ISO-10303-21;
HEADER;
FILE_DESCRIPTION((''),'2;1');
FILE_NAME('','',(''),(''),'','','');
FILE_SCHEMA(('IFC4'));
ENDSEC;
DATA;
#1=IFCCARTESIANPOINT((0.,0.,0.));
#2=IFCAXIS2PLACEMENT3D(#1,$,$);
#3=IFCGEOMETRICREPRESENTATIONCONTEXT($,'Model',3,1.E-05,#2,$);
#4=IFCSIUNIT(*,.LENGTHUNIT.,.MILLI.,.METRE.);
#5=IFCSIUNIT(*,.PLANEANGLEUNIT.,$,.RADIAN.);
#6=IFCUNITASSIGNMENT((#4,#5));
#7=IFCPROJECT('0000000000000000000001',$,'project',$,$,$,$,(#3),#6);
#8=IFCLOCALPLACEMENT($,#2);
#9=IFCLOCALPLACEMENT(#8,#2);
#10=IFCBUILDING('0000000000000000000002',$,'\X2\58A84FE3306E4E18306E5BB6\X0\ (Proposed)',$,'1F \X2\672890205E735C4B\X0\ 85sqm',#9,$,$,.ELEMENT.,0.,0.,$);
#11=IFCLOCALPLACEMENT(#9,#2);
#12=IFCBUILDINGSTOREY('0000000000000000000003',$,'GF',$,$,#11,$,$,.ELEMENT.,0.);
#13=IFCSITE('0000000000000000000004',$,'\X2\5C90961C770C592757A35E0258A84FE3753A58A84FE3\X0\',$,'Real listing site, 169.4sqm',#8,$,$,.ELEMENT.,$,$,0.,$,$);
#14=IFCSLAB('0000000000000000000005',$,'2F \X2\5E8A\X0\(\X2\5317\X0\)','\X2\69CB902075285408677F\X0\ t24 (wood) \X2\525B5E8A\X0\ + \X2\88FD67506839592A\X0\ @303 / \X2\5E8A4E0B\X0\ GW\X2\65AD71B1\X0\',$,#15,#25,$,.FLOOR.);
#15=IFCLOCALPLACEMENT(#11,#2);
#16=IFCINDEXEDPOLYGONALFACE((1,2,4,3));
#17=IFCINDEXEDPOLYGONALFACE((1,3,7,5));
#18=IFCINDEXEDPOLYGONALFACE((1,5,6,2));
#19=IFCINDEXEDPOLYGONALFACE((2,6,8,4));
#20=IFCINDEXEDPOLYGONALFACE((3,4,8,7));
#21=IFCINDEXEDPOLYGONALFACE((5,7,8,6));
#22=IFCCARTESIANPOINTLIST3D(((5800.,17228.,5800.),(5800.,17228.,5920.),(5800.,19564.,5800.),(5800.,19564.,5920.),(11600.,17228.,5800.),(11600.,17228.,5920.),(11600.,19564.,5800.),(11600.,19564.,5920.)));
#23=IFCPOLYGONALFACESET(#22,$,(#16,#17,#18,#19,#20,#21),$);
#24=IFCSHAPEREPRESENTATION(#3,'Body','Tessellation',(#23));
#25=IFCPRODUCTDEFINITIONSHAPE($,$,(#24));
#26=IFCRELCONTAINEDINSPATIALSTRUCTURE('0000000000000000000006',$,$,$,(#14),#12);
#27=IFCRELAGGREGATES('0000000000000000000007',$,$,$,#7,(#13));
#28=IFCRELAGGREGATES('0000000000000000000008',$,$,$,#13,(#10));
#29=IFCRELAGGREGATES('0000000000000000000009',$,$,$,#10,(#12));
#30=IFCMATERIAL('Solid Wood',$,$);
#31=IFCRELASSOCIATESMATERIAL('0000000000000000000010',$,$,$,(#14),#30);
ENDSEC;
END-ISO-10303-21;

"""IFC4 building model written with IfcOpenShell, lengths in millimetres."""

from ifc_helpers import new_model, si_unit, frame, frame_2d, origin, place, context, project, spatial, rectangle, extrude, material, element, save


model = new_model("IFC4")

# Units and contexts
model_context = context("Model", 3, precision=1e-05, world=origin())
ifc_project = project(units=[si_unit("LENGTHUNIT", "METRE", prefix="MILLI"), si_unit("PLANEANGLEUNIT", "RADIAN")], contexts=[model_context])

# Site, building, storey
site_placement = place(None, origin())
site = spatial("IfcSite", under=ifc_project, at=site_placement, Name="岐阜県大垣市墨俣町墨俣", ObjectType="Real listing site, 169.4sqm", CompositionType="ELEMENT", RefElevation=0.0)
building_placement = place(site_placement, origin())
building = spatial("IfcBuilding", under=site, at=building_placement, Name="墨俣の丘の家 (Proposed)", ObjectType="1F 木造平屋 85sqm", CompositionType="ELEMENT", ElevationOfRefHeight=0.0, ElevationOfTerrain=0.0)
storey_placement = place(building_placement, origin())
storey = spatial("IfcBuildingStorey", under=building, at=storey_placement, Name="GF", CompositionType="ELEMENT", Elevation=0.0)

# Slab
ifc_material_1 = material(Name="Solid Wood")
slab_placement = place(storey_placement, frame((2900.0, 8614.0, 2900.0)))
element("IfcSlab", 1, at=slab_placement, inside=storey, material=ifc_material_1, Name="2F 床(北)", Description="構造用合板 t24 (wood) 剛床 + 製材根太 @303 / 床下 GW断熱", PredefinedType="FLOOR", context=model_context, shape_type="SweptSolid", body=[
    extrude(rectangle(XDim=5800.0, YDim=2336.0, at=frame_2d((2900.0, 1168.0))), frame((2900.0, 8614.0, 2900.0)), (0.0, 0.0, 1.0), 120.0),
])

save(model, "model.ifc")
